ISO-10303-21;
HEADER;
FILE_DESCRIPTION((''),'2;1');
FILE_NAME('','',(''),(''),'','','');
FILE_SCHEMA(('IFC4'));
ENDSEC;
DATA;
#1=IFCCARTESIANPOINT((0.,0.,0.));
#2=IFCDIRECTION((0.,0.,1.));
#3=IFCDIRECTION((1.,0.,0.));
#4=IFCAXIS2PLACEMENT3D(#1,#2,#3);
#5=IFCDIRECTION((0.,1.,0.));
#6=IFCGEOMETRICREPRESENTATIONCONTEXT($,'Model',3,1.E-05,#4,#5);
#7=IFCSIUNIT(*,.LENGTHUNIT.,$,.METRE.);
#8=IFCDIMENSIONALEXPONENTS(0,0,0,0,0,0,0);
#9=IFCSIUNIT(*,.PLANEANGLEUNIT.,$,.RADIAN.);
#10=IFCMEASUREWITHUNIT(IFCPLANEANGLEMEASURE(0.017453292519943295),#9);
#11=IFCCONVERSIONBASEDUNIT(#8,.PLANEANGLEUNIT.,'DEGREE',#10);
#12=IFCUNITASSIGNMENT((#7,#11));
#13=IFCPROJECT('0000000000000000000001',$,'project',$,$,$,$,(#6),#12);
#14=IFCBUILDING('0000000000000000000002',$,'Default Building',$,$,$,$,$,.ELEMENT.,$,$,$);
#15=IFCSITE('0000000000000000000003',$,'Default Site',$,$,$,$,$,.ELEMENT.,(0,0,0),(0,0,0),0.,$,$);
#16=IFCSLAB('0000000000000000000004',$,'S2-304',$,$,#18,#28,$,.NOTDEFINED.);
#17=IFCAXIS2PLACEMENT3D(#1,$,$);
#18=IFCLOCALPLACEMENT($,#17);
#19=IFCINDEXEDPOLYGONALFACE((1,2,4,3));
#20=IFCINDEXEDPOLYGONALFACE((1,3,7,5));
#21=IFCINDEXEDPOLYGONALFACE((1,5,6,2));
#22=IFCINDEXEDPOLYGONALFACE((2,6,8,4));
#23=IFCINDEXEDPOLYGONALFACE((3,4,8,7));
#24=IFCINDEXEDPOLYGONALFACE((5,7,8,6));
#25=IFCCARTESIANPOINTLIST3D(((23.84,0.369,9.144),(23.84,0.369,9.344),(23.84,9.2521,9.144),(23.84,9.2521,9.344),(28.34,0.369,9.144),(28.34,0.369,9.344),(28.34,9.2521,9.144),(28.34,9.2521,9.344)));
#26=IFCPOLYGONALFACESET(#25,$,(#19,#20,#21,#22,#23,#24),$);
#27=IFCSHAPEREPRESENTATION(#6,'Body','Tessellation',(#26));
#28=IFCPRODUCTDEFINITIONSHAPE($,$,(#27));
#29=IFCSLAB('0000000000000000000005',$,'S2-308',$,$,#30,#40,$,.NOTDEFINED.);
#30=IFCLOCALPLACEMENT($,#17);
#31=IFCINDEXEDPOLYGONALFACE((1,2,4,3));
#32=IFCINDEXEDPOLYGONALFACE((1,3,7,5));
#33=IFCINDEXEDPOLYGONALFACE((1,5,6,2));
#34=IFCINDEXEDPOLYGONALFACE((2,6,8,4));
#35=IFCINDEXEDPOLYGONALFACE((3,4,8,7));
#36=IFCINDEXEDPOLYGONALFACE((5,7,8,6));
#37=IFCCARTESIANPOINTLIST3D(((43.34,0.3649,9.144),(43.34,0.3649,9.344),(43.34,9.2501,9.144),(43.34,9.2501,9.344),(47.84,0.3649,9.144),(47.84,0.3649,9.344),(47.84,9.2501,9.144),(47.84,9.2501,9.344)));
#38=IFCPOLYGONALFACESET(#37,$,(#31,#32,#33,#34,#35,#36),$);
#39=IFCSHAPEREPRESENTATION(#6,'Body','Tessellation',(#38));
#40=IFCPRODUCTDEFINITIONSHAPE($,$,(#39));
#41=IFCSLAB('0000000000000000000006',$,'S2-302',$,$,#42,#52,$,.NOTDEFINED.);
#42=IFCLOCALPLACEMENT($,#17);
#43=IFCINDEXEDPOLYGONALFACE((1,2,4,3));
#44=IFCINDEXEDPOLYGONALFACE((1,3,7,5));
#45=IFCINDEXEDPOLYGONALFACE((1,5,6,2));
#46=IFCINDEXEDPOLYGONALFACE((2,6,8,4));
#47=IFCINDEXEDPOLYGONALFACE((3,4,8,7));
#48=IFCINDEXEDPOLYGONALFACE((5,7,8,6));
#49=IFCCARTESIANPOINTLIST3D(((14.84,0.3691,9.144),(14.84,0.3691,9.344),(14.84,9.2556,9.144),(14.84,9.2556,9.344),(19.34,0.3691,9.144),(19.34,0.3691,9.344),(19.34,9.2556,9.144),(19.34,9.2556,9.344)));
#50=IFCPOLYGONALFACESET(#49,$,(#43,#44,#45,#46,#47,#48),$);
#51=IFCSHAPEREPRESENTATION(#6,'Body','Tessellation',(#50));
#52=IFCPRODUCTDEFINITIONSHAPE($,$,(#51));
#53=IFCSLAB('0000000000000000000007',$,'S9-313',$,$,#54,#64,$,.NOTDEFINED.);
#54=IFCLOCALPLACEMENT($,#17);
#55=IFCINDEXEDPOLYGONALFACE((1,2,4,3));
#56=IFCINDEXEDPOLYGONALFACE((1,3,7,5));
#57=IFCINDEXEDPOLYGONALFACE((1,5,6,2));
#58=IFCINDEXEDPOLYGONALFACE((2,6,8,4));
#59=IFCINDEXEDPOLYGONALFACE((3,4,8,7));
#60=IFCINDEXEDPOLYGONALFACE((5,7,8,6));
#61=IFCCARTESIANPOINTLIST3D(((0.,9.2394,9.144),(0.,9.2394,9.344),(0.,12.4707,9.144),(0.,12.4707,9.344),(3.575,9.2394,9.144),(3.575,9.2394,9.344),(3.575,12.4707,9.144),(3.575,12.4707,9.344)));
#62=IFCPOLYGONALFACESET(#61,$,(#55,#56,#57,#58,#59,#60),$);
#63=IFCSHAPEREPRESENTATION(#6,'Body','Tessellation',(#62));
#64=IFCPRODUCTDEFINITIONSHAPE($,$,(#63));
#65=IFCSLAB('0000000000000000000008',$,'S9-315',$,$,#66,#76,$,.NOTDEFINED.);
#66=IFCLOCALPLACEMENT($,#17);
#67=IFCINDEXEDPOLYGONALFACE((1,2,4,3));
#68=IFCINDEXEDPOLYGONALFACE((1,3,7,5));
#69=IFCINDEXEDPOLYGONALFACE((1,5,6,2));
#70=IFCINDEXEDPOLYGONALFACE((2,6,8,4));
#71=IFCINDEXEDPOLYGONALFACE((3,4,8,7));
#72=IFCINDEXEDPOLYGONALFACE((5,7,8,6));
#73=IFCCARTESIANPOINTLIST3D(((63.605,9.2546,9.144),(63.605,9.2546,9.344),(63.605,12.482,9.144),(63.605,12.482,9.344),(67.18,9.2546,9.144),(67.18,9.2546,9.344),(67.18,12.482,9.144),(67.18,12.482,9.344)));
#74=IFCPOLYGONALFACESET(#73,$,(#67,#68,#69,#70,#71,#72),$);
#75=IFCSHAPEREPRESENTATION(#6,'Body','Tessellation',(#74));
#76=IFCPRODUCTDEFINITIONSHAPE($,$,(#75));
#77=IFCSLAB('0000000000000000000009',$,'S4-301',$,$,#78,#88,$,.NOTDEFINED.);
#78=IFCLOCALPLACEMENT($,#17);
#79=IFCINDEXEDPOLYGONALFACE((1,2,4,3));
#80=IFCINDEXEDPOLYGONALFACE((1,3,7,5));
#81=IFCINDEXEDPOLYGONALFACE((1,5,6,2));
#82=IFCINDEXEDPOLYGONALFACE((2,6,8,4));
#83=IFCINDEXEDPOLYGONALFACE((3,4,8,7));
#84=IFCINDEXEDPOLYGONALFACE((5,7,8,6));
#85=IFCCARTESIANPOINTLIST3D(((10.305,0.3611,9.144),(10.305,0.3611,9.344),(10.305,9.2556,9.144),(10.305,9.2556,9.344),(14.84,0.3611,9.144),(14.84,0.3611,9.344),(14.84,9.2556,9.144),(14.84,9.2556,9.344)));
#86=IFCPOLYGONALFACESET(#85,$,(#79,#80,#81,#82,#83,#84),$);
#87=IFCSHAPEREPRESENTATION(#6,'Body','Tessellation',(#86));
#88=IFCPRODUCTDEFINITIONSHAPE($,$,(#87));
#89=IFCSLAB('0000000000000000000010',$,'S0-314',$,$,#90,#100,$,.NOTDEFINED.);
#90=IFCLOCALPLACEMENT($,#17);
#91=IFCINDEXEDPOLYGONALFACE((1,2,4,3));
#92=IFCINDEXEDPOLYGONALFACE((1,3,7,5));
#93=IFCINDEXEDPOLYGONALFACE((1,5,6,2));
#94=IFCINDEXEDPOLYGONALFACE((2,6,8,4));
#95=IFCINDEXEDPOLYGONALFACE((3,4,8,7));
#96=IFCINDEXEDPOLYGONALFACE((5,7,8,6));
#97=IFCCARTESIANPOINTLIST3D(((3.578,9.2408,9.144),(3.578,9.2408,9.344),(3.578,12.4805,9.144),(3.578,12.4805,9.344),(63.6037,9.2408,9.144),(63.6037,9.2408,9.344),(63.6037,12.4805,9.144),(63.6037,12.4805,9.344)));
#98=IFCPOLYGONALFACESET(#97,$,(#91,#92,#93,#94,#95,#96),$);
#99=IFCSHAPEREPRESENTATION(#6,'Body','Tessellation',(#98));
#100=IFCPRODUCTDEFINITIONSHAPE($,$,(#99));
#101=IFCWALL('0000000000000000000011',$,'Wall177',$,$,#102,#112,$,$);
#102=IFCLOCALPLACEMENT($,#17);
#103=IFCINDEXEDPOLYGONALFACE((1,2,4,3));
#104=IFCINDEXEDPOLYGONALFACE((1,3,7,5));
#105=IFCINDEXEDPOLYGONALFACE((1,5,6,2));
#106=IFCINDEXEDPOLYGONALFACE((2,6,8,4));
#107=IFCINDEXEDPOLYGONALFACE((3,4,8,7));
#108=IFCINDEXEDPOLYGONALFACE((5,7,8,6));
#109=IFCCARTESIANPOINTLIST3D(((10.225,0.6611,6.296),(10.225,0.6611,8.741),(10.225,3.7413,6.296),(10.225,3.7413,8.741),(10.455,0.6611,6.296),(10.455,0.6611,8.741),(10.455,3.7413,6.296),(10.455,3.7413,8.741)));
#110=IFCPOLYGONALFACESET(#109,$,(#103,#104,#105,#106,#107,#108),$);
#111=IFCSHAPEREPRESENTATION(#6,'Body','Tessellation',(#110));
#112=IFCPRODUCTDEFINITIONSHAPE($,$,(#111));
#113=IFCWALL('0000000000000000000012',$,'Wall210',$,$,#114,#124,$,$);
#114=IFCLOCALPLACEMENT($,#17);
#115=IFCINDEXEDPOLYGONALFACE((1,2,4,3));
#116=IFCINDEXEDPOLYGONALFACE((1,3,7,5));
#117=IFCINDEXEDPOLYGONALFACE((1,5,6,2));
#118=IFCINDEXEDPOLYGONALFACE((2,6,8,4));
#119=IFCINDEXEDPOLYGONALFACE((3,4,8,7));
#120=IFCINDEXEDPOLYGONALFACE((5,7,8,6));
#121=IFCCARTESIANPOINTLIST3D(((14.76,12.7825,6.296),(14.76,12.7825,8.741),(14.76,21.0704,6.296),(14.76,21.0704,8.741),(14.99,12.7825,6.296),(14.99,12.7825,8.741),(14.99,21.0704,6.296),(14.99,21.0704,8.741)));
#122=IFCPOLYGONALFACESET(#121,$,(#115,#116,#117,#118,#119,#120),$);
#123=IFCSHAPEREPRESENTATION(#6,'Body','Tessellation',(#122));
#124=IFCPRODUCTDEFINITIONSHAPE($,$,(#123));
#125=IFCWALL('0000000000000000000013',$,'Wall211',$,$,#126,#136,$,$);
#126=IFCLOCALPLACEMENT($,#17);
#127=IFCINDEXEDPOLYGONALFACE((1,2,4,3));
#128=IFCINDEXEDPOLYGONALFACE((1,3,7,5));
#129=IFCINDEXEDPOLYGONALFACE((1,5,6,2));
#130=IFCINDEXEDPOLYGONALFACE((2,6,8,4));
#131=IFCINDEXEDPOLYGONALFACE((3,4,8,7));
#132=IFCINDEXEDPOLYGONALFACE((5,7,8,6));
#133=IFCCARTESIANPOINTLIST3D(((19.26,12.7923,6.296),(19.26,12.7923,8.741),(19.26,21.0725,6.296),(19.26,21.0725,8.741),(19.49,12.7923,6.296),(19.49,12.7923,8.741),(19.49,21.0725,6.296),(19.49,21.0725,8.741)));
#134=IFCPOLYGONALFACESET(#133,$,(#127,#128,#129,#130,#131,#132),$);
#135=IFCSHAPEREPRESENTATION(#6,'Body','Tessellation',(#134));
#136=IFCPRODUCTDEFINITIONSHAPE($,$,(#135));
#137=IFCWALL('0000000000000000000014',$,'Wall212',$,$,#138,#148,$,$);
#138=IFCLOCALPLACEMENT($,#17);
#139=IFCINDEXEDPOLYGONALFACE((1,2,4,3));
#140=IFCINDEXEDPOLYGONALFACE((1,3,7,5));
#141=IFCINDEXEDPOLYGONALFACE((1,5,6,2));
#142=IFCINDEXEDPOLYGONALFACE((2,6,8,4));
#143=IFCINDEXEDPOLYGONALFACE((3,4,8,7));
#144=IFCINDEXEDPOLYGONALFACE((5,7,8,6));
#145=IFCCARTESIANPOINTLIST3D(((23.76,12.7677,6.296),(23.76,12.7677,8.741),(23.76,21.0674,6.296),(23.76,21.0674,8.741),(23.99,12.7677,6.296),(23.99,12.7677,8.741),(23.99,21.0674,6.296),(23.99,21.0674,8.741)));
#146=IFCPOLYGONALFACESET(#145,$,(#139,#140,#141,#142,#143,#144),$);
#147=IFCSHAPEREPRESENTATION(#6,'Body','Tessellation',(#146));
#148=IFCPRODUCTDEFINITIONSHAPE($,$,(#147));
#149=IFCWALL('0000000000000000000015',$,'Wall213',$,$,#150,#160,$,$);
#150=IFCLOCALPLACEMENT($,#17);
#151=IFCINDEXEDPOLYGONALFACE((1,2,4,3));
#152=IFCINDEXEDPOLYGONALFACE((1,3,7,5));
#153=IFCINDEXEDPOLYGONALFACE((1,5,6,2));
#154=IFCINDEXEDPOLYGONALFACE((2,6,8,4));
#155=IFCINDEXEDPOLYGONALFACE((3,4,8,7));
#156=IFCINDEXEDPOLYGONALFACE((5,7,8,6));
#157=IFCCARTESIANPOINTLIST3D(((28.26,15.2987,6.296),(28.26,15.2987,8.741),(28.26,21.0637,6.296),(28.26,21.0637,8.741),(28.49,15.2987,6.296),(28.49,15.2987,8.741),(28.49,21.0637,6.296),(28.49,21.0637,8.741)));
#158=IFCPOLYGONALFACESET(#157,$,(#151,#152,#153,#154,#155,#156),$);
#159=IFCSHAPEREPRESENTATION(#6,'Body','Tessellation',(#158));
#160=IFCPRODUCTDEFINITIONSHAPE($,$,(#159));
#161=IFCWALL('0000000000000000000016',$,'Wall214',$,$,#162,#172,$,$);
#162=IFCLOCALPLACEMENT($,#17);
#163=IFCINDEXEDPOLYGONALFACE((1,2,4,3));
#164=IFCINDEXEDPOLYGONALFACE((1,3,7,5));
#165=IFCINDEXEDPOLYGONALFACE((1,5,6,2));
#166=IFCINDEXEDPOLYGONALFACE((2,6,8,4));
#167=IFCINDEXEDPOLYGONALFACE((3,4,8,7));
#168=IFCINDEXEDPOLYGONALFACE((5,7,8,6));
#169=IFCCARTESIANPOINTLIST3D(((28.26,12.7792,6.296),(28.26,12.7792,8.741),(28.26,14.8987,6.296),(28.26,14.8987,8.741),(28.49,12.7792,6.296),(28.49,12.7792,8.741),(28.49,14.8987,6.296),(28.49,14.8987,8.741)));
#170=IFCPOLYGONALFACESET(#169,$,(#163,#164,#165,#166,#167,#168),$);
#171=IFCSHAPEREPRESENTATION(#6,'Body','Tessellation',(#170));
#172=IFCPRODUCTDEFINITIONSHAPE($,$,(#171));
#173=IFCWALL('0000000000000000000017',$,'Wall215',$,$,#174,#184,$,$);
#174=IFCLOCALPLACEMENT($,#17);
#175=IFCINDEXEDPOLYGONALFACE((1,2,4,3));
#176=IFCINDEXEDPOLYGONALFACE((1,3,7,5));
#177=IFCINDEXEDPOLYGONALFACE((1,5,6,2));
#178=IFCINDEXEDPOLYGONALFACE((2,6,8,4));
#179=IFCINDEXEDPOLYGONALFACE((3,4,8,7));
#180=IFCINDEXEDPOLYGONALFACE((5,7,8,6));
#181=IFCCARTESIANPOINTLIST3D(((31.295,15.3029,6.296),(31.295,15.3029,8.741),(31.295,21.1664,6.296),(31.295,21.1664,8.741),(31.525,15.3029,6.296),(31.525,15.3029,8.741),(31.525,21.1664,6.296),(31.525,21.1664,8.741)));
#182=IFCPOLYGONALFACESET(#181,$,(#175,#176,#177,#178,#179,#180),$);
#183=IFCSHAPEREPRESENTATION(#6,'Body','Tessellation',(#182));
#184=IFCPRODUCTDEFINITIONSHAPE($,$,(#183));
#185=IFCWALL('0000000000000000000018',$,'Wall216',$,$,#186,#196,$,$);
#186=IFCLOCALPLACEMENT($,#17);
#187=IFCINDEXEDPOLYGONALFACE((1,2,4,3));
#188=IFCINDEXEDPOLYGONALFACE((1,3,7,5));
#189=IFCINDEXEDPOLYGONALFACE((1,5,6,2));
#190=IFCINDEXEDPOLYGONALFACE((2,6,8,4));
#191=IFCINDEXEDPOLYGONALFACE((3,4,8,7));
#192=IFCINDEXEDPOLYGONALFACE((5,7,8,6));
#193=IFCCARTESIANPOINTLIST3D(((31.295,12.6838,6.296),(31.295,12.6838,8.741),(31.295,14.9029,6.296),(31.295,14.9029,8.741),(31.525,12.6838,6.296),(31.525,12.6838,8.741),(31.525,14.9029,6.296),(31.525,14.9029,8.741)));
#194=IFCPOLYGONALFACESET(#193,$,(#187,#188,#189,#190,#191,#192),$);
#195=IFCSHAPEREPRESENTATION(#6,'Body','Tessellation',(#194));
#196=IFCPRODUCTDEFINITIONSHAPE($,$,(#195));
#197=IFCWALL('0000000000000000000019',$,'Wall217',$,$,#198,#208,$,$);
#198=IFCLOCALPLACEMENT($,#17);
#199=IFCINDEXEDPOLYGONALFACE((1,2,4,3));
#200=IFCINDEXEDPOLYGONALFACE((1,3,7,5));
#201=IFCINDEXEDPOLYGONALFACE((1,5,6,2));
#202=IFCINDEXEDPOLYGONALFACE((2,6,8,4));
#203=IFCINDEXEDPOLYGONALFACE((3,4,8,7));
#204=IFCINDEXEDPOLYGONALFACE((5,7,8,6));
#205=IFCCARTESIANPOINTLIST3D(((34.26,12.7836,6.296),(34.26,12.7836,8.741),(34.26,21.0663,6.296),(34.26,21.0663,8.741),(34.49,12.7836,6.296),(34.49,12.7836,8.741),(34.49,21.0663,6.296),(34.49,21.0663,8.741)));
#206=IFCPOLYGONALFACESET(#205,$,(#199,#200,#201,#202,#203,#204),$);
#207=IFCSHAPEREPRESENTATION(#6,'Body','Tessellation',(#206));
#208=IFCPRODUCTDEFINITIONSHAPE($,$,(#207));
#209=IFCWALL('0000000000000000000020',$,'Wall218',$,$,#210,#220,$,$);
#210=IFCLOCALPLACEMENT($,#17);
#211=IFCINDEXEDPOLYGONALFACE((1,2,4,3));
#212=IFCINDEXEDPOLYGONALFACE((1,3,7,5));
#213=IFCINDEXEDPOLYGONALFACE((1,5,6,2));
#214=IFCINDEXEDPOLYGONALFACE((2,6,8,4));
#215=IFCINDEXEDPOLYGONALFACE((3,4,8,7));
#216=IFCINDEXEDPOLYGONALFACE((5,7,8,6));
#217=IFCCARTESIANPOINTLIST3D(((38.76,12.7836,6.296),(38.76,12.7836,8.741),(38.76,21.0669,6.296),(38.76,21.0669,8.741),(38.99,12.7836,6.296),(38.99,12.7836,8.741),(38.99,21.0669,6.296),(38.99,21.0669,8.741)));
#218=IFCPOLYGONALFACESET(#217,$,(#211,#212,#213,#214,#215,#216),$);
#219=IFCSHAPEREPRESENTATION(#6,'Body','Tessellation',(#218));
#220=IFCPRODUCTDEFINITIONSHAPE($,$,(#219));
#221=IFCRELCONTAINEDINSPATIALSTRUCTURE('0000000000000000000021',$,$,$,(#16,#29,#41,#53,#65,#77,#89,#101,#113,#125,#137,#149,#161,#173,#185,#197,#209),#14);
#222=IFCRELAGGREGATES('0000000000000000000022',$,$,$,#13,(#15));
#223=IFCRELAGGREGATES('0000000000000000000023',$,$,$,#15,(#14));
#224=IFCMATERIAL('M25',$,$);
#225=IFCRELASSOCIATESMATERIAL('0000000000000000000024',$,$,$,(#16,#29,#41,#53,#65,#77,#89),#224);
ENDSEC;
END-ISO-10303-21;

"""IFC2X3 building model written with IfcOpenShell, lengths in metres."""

from ifc_helpers import new_model, entity, si_unit, converted_unit, direction, frame, frame_2d, origin_with_axes, place, context, project, spatial, rectangle, extrude, material, element, save


model = new_model("IFC2X3")

# Units and contexts
model_context = context("Model", 3, precision=1e-05, world=origin_with_axes(), true_north=direction((0.0, 1.0, 0.0)))
ifc_project = project(units=[si_unit("LENGTHUNIT", "METRE"), converted_unit("PLANEANGLEUNIT", "DEGREE", entity("IfcPlaneAngleMeasure", 0.017453292519943295), si_unit("PLANEANGLEUNIT", "RADIAN"), dimensions=[0, 0, 0, 0, 0, 0, 0])], contexts=[model_context])

# Site, building
site = spatial("IfcSite", under=ifc_project, Name="Default Site", CompositionType="ELEMENT", RefLatitude=(0, 0, 0), RefLongitude=(0, 0, 0), RefElevation=0.0)
building = spatial("IfcBuilding", under=site, Name="Default Building", CompositionType="ELEMENT")

# Slabs
ifc_material = material(Name="M25")
placement = place(None, origin_with_axes())
element("IfcSlab", 1, at=placement, inside=building, material=ifc_material, Name="S2-304", PredefinedType="NOTDEFINED", context=model_context, shape_type="SweptSolid", body=[
    extrude(rectangle(XDim=4.5, YDim=8.8831, at=frame_2d((0.0, 0.0), x_axis=(1.0, 0.0, 0.0))), frame((26.09, 4.8106, 9.144), z_axis=(0.0, 0.0, 1.0), x_axis=(1.0, 0.0, 0.0)), (0.0, 0.0, 1.0), 0.2),
])
element("IfcSlab", 2, at=placement, inside=building, material=ifc_material, Name="S2-308", PredefinedType="NOTDEFINED", context=model_context, shape_type="SweptSolid", body=[
    extrude(rectangle(XDim=4.5, YDim=8.8852, at=frame_2d((0.0, 0.0), x_axis=(1.0, 0.0, 0.0))), frame((45.59, 4.8075, 9.144), z_axis=(0.0, 0.0, 1.0), x_axis=(1.0, 0.0, 0.0)), (0.0, 0.0, 1.0), 0.2),
])
element("IfcSlab", 3, at=placement, inside=building, material=ifc_material, Name="S2-302", PredefinedType="NOTDEFINED", context=model_context, shape_type="SweptSolid", body=[
    extrude(rectangle(XDim=4.5, YDim=8.8865, at=frame_2d((0.0, 0.0), x_axis=(1.0, 0.0, 0.0))), frame((17.09, 4.8123, 9.144), z_axis=(0.0, 0.0, 1.0), x_axis=(1.0, 0.0, 0.0)), (0.0, 0.0, 1.0), 0.2),
])
element("IfcSlab", 4, at=placement, inside=building, material=ifc_material, Name="S9-313", PredefinedType="NOTDEFINED", context=model_context, shape_type="SweptSolid", body=[
    extrude(rectangle(XDim=3.575, YDim=3.2313, at=frame_2d((0.0, 0.0), x_axis=(1.0, 0.0, 0.0))), frame((1.7875, 10.8551, 9.144), z_axis=(0.0, 0.0, 1.0), x_axis=(1.0, 0.0, 0.0)), (0.0, 0.0, 1.0), 0.2),
])
element("IfcSlab", 5, at=placement, inside=building, material=ifc_material, Name="S9-315", PredefinedType="NOTDEFINED", context=model_context, shape_type="SweptSolid", body=[
    extrude(rectangle(XDim=3.575, YDim=3.2274, at=frame_2d((0.0, 0.0), x_axis=(1.0, 0.0, 0.0))), frame((65.3925, 10.8683, 9.144), z_axis=(0.0, 0.0, 1.0), x_axis=(1.0, 0.0, 0.0)), (0.0, 0.0, 1.0), 0.2),
])
element("IfcSlab", 6, at=placement, inside=building, material=ifc_material, Name="S4-301", PredefinedType="NOTDEFINED", context=model_context, shape_type="SweptSolid", body=[
    extrude(rectangle(XDim=4.535, YDim=8.8945, at=frame_2d((0.0, 0.0), x_axis=(1.0, 0.0, 0.0))), frame((12.5725, 4.8083, 9.144), z_axis=(0.0, 0.0, 1.0), x_axis=(1.0, 0.0, 0.0)), (0.0, 0.0, 1.0), 0.2),
])
element("IfcSlab", 7, at=placement, inside=building, material=ifc_material, Name="S0-314", PredefinedType="NOTDEFINED", context=model_context, shape_type="SweptSolid", body=[
    extrude(rectangle(XDim=60.0257, YDim=3.2396, at=frame_2d((0.0, 0.0), x_axis=(1.0, 0.0, 0.0))), frame((33.5909, 10.8606, 9.144), z_axis=(0.0, 0.0, 1.0), x_axis=(1.0, 0.0, 0.0)), (0.0, 0.0, 1.0), 0.2),
])

# Walls
element("IfcWall", 8, at=placement, inside=building, Name="Wall177", context=model_context, shape_type="SweptSolid", body=[
    extrude(rectangle(XDim=3.0802, YDim=0.23, at=frame_2d((0.0, 0.0), x_axis=(0.0, -1.0, 0.0))), frame((10.34, 2.2012, 6.296), z_axis=(0.0, 0.0, 1.0), x_axis=(1.0, 0.0, 0.0)), (0.0, 0.0, 1.0), 2.445),
])
element("IfcWall", 9, at=placement, inside=building, Name="Wall210", context=model_context, shape_type="SweptSolid", body=[
    extrude(rectangle(XDim=8.2879, YDim=0.23, at=frame_2d((0.0, 0.0), x_axis=(0.0, -1.0, 0.0))), frame((14.875, 16.9264, 6.296), z_axis=(0.0, 0.0, 1.0), x_axis=(1.0, 0.0, 0.0)), (0.0, 0.0, 1.0), 2.445),
])
element("IfcWall", 10, at=placement, inside=building, Name="Wall211", context=model_context, shape_type="SweptSolid", body=[
    extrude(rectangle(XDim=8.2802, YDim=0.23, at=frame_2d((0.0, 0.0), x_axis=(0.0, -1.0, 0.0))), frame((19.375, 16.9324, 6.296), z_axis=(0.0, 0.0, 1.0), x_axis=(1.0, 0.0, 0.0)), (0.0, 0.0, 1.0), 2.445),
])
element("IfcWall", 11, at=placement, inside=building, Name="Wall212", context=model_context, shape_type="SweptSolid", body=[
    extrude(rectangle(XDim=8.2997, YDim=0.23, at=frame_2d((0.0, 0.0), x_axis=(0.0, -1.0, 0.0))), frame((23.875, 16.9175, 6.296), z_axis=(0.0, 0.0, 1.0), x_axis=(1.0, 0.0, 0.0)), (0.0, 0.0, 1.0), 2.445),
])
element("IfcWall", 12, at=placement, inside=building, Name="Wall213", context=model_context, shape_type="SweptSolid", body=[
    extrude(rectangle(XDim=5.765, YDim=0.23, at=frame_2d((0.0, 0.0), x_axis=(0.0, -1.0, 0.0))), frame((28.375, 18.1812, 6.296), z_axis=(0.0, 0.0, 1.0), x_axis=(1.0, 0.0, 0.0)), (0.0, 0.0, 1.0), 2.445),
])
element("IfcWall", 13, at=placement, inside=building, Name="Wall214", context=model_context, shape_type="SweptSolid", body=[
    extrude(rectangle(XDim=2.1195, YDim=0.23, at=frame_2d((0.0, 0.0), x_axis=(0.0, 1.0, 0.0))), frame((28.375, 13.8389, 6.296), z_axis=(0.0, 0.0, 1.0), x_axis=(1.0, 0.0, 0.0)), (0.0, 0.0, 1.0), 2.445),
])
element("IfcWall", 14, at=placement, inside=building, Name="Wall215", context=model_context, shape_type="SweptSolid", body=[
    extrude(rectangle(XDim=5.8635, YDim=0.23, at=frame_2d((0.0, 0.0), x_axis=(0.0, -1.0, 0.0))), frame((31.41, 18.2346, 6.296), z_axis=(0.0, 0.0, 1.0), x_axis=(1.0, 0.0, 0.0)), (0.0, 0.0, 1.0), 2.445),
])
element("IfcWall", 15, at=placement, inside=building, Name="Wall216", context=model_context, shape_type="SweptSolid", body=[
    extrude(rectangle(XDim=2.2191, YDim=0.23, at=frame_2d((0.0, 0.0), x_axis=(0.0, 1.0, 0.0))), frame((31.41, 13.7934, 6.296), z_axis=(0.0, 0.0, 1.0), x_axis=(1.0, 0.0, 0.0)), (0.0, 0.0, 1.0), 2.445),
])
element("IfcWall", 16, at=placement, inside=building, Name="Wall217", context=model_context, shape_type="SweptSolid", body=[
    extrude(rectangle(XDim=8.2827, YDim=0.23, at=frame_2d((0.0, 0.0), x_axis=(0.0, -1.0, 0.0))), frame((34.375, 16.925, 6.296), z_axis=(0.0, 0.0, 1.0), x_axis=(1.0, 0.0, 0.0)), (0.0, 0.0, 1.0), 2.445),
])
element("IfcWall", 17, at=placement, inside=building, Name="Wall218", context=model_context, shape_type="SweptSolid", body=[
    extrude(rectangle(XDim=8.2833, YDim=0.23, at=frame_2d((0.0, 0.0), x_axis=(0.0, -1.0, 0.0))), frame((38.875, 16.9253, 6.296), z_axis=(0.0, 0.0, 1.0), x_axis=(1.0, 0.0, 0.0)), (0.0, 0.0, 1.0), 2.445),
])

save(model, "model.ifc")
